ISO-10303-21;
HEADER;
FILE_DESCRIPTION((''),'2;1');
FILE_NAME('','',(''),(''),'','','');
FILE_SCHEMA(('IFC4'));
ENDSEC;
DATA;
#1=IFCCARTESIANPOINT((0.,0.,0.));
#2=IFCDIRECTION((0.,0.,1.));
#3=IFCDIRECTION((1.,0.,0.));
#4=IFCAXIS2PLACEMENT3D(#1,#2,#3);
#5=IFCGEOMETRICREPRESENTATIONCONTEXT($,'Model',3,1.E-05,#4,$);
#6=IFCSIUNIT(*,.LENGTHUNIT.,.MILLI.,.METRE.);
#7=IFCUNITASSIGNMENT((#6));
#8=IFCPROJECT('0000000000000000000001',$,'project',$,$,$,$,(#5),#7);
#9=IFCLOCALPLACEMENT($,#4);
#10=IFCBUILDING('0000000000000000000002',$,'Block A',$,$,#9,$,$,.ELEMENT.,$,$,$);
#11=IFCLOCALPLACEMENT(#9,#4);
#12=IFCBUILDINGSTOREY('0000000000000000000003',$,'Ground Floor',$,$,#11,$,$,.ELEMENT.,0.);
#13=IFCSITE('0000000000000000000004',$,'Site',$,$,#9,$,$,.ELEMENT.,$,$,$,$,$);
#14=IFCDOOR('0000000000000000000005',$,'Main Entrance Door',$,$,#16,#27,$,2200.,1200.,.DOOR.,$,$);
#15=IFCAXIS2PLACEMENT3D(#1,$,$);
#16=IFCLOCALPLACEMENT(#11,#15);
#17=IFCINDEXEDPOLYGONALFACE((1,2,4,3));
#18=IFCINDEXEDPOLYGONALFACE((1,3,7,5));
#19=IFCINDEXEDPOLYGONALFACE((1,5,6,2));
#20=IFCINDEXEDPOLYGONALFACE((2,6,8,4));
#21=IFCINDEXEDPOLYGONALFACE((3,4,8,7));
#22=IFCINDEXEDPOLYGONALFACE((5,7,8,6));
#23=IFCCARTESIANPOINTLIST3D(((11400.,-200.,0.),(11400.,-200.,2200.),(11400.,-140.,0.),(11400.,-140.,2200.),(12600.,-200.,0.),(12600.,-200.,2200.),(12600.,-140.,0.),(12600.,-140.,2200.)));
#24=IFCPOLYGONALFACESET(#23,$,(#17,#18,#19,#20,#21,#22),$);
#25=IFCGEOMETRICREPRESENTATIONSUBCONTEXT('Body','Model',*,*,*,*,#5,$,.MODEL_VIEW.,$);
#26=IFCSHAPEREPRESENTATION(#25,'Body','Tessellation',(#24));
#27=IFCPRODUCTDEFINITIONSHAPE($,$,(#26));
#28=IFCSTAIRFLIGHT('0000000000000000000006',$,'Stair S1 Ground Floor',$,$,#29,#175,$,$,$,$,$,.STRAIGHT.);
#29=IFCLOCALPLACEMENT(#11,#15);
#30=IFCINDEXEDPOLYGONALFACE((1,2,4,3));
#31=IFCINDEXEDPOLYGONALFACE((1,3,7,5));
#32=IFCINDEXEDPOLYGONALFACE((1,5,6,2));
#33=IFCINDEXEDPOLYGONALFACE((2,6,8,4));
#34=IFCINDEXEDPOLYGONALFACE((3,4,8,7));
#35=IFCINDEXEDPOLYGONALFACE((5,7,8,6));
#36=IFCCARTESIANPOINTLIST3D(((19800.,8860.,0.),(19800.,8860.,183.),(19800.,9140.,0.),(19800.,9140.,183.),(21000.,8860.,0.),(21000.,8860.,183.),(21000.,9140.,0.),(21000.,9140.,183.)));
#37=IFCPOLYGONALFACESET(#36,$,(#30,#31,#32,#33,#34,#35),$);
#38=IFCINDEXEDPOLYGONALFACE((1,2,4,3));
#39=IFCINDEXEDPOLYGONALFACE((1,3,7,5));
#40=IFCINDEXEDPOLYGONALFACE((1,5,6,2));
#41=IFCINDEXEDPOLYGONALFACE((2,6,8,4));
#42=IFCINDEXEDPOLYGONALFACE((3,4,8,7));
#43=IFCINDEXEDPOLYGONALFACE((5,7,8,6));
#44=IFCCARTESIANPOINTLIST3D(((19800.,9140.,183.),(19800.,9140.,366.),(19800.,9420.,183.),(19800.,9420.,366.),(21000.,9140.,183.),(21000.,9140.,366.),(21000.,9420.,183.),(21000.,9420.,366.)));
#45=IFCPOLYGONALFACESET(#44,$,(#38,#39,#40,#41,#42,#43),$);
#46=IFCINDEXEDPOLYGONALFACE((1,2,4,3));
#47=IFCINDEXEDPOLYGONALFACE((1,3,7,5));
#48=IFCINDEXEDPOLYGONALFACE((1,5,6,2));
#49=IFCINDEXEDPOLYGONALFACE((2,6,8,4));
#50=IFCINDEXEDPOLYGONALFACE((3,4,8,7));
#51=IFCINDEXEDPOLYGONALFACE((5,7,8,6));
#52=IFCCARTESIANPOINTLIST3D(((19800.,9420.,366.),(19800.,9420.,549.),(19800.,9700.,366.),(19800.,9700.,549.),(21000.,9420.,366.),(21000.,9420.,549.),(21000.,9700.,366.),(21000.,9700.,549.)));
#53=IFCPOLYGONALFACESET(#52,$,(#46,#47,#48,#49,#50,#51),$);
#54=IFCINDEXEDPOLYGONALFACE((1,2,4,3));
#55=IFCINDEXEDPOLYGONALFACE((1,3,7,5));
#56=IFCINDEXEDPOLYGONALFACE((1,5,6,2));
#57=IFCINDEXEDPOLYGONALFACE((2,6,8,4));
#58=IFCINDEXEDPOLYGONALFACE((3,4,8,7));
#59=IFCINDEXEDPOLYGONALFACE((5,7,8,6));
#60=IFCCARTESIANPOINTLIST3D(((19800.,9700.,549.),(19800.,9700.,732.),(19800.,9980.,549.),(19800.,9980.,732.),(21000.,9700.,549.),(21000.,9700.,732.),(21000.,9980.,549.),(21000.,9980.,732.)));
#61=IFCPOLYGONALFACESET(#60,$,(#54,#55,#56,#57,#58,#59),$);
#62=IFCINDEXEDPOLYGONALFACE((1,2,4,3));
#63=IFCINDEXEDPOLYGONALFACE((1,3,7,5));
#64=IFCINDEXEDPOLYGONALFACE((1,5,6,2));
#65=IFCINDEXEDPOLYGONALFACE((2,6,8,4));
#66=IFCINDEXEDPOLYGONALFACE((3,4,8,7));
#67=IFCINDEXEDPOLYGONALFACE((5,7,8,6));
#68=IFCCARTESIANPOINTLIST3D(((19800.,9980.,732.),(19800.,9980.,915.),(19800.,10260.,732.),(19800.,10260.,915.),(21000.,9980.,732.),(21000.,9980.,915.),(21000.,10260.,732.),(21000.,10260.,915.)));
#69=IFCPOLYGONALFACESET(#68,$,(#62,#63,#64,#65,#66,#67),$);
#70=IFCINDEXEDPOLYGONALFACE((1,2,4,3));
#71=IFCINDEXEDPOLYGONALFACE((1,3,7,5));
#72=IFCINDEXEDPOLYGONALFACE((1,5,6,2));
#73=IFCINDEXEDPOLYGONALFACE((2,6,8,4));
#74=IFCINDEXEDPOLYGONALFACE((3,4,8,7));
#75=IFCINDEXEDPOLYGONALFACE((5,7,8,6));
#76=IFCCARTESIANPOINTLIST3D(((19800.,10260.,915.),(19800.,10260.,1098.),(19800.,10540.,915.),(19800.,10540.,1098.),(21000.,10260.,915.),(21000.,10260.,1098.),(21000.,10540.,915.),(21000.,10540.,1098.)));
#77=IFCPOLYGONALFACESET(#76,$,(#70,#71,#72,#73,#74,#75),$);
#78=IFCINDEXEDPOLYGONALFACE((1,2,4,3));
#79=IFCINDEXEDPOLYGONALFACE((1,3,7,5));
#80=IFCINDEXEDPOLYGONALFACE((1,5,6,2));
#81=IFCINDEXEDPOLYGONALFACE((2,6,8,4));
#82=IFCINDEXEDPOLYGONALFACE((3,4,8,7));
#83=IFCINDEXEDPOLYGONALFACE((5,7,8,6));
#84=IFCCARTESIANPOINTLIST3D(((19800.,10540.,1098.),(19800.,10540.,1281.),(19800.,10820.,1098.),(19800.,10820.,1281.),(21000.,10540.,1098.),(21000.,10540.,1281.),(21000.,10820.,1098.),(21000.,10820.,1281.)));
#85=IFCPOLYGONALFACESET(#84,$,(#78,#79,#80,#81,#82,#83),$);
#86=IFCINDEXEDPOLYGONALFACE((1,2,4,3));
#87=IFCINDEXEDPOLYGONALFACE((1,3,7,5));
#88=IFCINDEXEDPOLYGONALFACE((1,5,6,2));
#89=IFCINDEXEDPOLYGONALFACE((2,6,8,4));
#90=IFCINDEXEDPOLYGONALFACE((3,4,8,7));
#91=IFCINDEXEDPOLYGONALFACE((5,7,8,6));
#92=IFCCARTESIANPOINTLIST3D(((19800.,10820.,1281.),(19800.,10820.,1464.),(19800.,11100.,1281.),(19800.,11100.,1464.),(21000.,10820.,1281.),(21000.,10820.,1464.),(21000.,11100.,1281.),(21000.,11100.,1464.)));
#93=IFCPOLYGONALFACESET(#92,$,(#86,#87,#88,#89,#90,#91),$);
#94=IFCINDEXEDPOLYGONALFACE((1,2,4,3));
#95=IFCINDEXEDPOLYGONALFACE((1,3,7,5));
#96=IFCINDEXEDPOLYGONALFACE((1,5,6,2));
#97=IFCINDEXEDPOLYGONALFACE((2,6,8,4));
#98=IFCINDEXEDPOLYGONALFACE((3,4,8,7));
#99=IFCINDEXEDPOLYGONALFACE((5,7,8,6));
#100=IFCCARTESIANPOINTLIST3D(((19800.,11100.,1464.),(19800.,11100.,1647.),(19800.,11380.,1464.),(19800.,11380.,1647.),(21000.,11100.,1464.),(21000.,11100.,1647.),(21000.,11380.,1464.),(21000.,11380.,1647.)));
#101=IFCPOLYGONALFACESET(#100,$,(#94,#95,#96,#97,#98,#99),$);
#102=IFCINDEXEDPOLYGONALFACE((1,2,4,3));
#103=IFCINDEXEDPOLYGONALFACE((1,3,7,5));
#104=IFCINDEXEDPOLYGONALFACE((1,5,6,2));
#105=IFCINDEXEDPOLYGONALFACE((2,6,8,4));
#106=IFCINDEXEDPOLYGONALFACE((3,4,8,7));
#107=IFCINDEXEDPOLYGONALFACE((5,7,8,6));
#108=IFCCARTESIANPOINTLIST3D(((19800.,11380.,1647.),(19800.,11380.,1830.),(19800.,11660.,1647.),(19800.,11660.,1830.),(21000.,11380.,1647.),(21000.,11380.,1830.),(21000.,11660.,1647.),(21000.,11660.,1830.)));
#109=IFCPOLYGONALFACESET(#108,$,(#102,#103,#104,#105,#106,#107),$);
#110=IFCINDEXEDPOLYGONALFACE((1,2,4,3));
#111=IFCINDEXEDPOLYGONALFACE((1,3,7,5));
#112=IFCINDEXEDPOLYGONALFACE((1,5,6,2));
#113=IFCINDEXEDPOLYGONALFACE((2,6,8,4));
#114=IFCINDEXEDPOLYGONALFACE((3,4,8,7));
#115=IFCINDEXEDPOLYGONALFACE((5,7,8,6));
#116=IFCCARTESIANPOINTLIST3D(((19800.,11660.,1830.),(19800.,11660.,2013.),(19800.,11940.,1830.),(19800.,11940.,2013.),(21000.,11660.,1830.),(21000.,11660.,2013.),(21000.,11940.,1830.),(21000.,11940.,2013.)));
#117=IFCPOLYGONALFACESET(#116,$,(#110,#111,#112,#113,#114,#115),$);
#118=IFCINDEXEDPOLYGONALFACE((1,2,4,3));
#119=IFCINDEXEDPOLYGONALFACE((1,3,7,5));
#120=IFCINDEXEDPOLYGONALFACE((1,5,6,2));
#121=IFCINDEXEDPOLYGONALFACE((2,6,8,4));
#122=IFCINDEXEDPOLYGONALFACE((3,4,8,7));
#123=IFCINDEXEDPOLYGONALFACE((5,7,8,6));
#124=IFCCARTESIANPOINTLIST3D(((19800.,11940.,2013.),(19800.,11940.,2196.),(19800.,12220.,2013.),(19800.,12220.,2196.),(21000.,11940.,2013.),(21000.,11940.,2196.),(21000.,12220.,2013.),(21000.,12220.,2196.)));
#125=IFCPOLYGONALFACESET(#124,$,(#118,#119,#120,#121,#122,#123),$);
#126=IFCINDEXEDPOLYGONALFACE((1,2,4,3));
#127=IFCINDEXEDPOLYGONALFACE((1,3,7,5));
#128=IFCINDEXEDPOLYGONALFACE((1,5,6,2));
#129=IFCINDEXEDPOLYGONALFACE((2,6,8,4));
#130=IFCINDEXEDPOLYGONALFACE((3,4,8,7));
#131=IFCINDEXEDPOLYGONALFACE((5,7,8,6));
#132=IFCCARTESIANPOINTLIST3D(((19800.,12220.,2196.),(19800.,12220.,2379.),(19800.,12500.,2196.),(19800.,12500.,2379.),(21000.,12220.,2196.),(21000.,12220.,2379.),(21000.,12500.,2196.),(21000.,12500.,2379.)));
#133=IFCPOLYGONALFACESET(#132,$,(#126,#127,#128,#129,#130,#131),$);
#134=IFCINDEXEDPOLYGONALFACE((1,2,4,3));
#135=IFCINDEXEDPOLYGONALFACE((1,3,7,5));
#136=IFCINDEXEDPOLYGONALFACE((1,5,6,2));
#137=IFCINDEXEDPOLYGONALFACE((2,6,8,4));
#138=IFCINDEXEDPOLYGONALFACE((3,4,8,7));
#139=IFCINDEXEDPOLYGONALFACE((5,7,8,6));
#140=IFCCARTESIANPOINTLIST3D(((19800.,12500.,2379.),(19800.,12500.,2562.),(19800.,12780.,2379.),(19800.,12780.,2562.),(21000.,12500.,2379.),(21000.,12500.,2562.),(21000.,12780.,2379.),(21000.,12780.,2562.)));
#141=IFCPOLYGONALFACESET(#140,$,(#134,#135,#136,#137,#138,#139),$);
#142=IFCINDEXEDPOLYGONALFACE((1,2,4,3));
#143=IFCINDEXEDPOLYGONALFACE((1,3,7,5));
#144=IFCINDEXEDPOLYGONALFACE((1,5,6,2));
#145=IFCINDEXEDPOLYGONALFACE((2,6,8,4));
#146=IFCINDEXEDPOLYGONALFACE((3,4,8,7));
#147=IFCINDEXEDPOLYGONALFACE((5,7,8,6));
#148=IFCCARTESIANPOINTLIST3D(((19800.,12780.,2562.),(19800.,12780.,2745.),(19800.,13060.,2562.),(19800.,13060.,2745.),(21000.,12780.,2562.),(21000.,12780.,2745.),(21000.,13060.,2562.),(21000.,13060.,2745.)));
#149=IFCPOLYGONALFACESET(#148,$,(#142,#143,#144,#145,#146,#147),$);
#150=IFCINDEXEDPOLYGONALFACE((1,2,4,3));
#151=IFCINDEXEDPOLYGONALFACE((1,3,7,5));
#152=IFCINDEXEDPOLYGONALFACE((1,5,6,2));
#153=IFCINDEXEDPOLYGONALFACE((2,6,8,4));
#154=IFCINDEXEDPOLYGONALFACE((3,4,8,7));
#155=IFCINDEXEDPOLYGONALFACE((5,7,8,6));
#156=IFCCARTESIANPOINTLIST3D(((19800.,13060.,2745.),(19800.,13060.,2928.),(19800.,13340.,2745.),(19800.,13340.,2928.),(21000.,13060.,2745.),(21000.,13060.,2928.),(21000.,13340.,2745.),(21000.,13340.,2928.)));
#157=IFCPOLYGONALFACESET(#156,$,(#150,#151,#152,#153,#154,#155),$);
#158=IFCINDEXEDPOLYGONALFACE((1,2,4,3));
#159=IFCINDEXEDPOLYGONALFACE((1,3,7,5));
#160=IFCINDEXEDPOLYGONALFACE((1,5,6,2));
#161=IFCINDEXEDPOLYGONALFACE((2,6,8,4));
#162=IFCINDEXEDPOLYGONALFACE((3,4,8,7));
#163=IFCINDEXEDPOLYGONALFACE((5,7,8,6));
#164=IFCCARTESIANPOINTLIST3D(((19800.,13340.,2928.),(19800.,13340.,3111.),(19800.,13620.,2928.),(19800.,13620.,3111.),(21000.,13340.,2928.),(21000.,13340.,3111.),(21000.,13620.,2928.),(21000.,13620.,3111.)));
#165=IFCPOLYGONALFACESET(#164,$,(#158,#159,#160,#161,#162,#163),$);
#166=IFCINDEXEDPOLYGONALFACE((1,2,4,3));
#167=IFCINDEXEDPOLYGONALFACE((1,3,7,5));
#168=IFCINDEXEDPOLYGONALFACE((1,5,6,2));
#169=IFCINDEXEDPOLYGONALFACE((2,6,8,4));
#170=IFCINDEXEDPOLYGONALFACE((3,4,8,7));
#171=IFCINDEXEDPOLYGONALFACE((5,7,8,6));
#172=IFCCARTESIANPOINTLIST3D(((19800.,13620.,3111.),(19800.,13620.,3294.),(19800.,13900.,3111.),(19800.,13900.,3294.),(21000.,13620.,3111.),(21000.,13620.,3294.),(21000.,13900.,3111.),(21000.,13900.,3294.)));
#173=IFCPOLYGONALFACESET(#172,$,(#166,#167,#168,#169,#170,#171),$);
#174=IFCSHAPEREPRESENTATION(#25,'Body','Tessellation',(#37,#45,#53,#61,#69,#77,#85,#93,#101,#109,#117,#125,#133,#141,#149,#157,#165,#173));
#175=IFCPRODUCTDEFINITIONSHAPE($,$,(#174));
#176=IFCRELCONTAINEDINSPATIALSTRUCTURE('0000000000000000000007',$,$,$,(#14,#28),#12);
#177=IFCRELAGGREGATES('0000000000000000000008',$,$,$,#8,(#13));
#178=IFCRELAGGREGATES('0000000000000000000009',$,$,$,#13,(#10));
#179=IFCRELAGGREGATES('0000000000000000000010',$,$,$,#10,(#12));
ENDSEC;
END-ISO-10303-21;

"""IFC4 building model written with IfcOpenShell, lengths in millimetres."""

from ifc_helpers import new_model, si_unit, frame, frame_2d, origin, origin_with_axes, origin_2d, place, context, subcontext, project, spatial, rectangle, extrude, element, save


model = new_model("IFC4")

# Units and contexts
model_context = context("Model", 3, precision=1e-05, world=origin_with_axes())
body_context = subcontext(model_context, "Body", "Model", "MODEL_VIEW")
ifc_project = project(units=[si_unit("LENGTHUNIT", "METRE", prefix="MILLI")], contexts=[model_context])

# Site, building, storey
placement = place(None, origin_with_axes())
site = spatial("IfcSite", under=ifc_project, at=placement, Name="Site", CompositionType="ELEMENT")
building = spatial("IfcBuilding", under=site, at=placement, Name="Block A", CompositionType="ELEMENT")
storey_placement = place(placement, origin_with_axes())
storey = spatial("IfcBuildingStorey", under=building, at=storey_placement, Name="Ground Floor", CompositionType="ELEMENT", Elevation=0.0)

# Door
door_placement = place(placement, frame((11400.0, -200.0, 0.0), z_axis=(0.0, 0.0, 1.0), x_axis=(1.0, 0.0, 0.0)))
element("IfcDoor", 1, at=door_placement, inside=storey, Name="Main Entrance Door", OverallHeight=2200.0, OverallWidth=1200.0, PredefinedType="DOOR", context=body_context, shape_type="SweptSolid", body=[
    extrude(rectangle(XDim=1200.0, YDim=60.0, at=frame_2d((600.0, 30.0))), origin_with_axes(), (0.0, 0.0, 1.0), 2200.0),
])

# Stair flight
stair_flight_placement = place(placement, frame((20400.0, 9000.0, 0.0), z_axis=(0.0, 0.0, 1.0), x_axis=(1.0, 0.0, 0.0)))
element("IfcStairFlight", 2, at=stair_flight_placement, inside=storey, Name="Stair S1 Ground Floor", PredefinedType="STRAIGHT", context=body_context, shape_type="SweptSolid", body=[
    extrude(rectangle(XDim=1200.0, YDim=280.0, at=origin_2d()), origin(), (0.0, 0.0, 1.0), 183.0),
    extrude(rectangle(XDim=1200.0, YDim=280.0, at=origin_2d()), frame((0.0, 280.0, 183.0)), (0.0, 0.0, 1.0), 183.0),
    extrude(rectangle(XDim=1200.0, YDim=280.0, at=origin_2d()), frame((0.0, 560.0, 366.0)), (0.0, 0.0, 1.0), 183.0),
    extrude(rectangle(XDim=1200.0, YDim=280.0, at=origin_2d()), frame((0.0, 840.0, 549.0)), (0.0, 0.0, 1.0), 183.0),
    extrude(rectangle(XDim=1200.0, YDim=280.0, at=origin_2d()), frame((0.0, 1120.0, 732.0)), (0.0, 0.0, 1.0), 183.0),
    extrude(rectangle(XDim=1200.0, YDim=280.0, at=origin_2d()), frame((0.0, 1400.0, 915.0)), (0.0, 0.0, 1.0), 183.0),
    extrude(rectangle(XDim=1200.0, YDim=280.0, at=origin_2d()), frame((0.0, 1680.0, 1098.0)), (0.0, 0.0, 1.0), 183.0),
    extrude(rectangle(XDim=1200.0, YDim=280.0, at=origin_2d()), frame((0.0, 1960.0, 1281.0)), (0.0, 0.0, 1.0), 183.0),
    extrude(rectangle(XDim=1200.0, YDim=280.0, at=origin_2d()), frame((0.0, 2240.0, 1464.0)), (0.0, 0.0, 1.0), 183.0),
    extrude(rectangle(XDim=1200.0, YDim=280.0, at=origin_2d()), frame((0.0, 2520.0, 1647.0)), (0.0, 0.0, 1.0), 183.0),
    extrude(rectangle(XDim=1200.0, YDim=280.0, at=origin_2d()), frame((0.0, 2800.0, 1830.0)), (0.0, 0.0, 1.0), 183.0),
    extrude(rectangle(XDim=1200.0, YDim=280.0, at=origin_2d()), frame((0.0, 3080.0, 2013.0)), (0.0, 0.0, 1.0), 183.0),
    extrude(rectangle(XDim=1200.0, YDim=280.0, at=origin_2d()), frame((0.0, 3360.0, 2196.0)), (0.0, 0.0, 1.0), 183.0),
    extrude(rectangle(XDim=1200.0, YDim=280.0, at=origin_2d()), frame((0.0, 3640.0, 2379.0)), (0.0, 0.0, 1.0), 183.0),
    extrude(rectangle(XDim=1200.0, YDim=280.0, at=origin_2d()), frame((0.0, 3920.0, 2562.0)), (0.0, 0.0, 1.0), 183.0),
    extrude(rectangle(XDim=1200.0, YDim=280.0, at=origin_2d()), frame((0.0, 4200.0, 2745.0)), (0.0, 0.0, 1.0), 183.0),
    extrude(rectangle(XDim=1200.0, YDim=280.0, at=origin_2d()), frame((0.0, 4480.0, 2928.0)), (0.0, 0.0, 1.0), 183.0),
    extrude(rectangle(XDim=1200.0, YDim=280.0, at=origin_2d()), frame((0.0, 4760.0, 3111.0)), (0.0, 0.0, 1.0), 183.0),
])

save(model, "model.ifc")
